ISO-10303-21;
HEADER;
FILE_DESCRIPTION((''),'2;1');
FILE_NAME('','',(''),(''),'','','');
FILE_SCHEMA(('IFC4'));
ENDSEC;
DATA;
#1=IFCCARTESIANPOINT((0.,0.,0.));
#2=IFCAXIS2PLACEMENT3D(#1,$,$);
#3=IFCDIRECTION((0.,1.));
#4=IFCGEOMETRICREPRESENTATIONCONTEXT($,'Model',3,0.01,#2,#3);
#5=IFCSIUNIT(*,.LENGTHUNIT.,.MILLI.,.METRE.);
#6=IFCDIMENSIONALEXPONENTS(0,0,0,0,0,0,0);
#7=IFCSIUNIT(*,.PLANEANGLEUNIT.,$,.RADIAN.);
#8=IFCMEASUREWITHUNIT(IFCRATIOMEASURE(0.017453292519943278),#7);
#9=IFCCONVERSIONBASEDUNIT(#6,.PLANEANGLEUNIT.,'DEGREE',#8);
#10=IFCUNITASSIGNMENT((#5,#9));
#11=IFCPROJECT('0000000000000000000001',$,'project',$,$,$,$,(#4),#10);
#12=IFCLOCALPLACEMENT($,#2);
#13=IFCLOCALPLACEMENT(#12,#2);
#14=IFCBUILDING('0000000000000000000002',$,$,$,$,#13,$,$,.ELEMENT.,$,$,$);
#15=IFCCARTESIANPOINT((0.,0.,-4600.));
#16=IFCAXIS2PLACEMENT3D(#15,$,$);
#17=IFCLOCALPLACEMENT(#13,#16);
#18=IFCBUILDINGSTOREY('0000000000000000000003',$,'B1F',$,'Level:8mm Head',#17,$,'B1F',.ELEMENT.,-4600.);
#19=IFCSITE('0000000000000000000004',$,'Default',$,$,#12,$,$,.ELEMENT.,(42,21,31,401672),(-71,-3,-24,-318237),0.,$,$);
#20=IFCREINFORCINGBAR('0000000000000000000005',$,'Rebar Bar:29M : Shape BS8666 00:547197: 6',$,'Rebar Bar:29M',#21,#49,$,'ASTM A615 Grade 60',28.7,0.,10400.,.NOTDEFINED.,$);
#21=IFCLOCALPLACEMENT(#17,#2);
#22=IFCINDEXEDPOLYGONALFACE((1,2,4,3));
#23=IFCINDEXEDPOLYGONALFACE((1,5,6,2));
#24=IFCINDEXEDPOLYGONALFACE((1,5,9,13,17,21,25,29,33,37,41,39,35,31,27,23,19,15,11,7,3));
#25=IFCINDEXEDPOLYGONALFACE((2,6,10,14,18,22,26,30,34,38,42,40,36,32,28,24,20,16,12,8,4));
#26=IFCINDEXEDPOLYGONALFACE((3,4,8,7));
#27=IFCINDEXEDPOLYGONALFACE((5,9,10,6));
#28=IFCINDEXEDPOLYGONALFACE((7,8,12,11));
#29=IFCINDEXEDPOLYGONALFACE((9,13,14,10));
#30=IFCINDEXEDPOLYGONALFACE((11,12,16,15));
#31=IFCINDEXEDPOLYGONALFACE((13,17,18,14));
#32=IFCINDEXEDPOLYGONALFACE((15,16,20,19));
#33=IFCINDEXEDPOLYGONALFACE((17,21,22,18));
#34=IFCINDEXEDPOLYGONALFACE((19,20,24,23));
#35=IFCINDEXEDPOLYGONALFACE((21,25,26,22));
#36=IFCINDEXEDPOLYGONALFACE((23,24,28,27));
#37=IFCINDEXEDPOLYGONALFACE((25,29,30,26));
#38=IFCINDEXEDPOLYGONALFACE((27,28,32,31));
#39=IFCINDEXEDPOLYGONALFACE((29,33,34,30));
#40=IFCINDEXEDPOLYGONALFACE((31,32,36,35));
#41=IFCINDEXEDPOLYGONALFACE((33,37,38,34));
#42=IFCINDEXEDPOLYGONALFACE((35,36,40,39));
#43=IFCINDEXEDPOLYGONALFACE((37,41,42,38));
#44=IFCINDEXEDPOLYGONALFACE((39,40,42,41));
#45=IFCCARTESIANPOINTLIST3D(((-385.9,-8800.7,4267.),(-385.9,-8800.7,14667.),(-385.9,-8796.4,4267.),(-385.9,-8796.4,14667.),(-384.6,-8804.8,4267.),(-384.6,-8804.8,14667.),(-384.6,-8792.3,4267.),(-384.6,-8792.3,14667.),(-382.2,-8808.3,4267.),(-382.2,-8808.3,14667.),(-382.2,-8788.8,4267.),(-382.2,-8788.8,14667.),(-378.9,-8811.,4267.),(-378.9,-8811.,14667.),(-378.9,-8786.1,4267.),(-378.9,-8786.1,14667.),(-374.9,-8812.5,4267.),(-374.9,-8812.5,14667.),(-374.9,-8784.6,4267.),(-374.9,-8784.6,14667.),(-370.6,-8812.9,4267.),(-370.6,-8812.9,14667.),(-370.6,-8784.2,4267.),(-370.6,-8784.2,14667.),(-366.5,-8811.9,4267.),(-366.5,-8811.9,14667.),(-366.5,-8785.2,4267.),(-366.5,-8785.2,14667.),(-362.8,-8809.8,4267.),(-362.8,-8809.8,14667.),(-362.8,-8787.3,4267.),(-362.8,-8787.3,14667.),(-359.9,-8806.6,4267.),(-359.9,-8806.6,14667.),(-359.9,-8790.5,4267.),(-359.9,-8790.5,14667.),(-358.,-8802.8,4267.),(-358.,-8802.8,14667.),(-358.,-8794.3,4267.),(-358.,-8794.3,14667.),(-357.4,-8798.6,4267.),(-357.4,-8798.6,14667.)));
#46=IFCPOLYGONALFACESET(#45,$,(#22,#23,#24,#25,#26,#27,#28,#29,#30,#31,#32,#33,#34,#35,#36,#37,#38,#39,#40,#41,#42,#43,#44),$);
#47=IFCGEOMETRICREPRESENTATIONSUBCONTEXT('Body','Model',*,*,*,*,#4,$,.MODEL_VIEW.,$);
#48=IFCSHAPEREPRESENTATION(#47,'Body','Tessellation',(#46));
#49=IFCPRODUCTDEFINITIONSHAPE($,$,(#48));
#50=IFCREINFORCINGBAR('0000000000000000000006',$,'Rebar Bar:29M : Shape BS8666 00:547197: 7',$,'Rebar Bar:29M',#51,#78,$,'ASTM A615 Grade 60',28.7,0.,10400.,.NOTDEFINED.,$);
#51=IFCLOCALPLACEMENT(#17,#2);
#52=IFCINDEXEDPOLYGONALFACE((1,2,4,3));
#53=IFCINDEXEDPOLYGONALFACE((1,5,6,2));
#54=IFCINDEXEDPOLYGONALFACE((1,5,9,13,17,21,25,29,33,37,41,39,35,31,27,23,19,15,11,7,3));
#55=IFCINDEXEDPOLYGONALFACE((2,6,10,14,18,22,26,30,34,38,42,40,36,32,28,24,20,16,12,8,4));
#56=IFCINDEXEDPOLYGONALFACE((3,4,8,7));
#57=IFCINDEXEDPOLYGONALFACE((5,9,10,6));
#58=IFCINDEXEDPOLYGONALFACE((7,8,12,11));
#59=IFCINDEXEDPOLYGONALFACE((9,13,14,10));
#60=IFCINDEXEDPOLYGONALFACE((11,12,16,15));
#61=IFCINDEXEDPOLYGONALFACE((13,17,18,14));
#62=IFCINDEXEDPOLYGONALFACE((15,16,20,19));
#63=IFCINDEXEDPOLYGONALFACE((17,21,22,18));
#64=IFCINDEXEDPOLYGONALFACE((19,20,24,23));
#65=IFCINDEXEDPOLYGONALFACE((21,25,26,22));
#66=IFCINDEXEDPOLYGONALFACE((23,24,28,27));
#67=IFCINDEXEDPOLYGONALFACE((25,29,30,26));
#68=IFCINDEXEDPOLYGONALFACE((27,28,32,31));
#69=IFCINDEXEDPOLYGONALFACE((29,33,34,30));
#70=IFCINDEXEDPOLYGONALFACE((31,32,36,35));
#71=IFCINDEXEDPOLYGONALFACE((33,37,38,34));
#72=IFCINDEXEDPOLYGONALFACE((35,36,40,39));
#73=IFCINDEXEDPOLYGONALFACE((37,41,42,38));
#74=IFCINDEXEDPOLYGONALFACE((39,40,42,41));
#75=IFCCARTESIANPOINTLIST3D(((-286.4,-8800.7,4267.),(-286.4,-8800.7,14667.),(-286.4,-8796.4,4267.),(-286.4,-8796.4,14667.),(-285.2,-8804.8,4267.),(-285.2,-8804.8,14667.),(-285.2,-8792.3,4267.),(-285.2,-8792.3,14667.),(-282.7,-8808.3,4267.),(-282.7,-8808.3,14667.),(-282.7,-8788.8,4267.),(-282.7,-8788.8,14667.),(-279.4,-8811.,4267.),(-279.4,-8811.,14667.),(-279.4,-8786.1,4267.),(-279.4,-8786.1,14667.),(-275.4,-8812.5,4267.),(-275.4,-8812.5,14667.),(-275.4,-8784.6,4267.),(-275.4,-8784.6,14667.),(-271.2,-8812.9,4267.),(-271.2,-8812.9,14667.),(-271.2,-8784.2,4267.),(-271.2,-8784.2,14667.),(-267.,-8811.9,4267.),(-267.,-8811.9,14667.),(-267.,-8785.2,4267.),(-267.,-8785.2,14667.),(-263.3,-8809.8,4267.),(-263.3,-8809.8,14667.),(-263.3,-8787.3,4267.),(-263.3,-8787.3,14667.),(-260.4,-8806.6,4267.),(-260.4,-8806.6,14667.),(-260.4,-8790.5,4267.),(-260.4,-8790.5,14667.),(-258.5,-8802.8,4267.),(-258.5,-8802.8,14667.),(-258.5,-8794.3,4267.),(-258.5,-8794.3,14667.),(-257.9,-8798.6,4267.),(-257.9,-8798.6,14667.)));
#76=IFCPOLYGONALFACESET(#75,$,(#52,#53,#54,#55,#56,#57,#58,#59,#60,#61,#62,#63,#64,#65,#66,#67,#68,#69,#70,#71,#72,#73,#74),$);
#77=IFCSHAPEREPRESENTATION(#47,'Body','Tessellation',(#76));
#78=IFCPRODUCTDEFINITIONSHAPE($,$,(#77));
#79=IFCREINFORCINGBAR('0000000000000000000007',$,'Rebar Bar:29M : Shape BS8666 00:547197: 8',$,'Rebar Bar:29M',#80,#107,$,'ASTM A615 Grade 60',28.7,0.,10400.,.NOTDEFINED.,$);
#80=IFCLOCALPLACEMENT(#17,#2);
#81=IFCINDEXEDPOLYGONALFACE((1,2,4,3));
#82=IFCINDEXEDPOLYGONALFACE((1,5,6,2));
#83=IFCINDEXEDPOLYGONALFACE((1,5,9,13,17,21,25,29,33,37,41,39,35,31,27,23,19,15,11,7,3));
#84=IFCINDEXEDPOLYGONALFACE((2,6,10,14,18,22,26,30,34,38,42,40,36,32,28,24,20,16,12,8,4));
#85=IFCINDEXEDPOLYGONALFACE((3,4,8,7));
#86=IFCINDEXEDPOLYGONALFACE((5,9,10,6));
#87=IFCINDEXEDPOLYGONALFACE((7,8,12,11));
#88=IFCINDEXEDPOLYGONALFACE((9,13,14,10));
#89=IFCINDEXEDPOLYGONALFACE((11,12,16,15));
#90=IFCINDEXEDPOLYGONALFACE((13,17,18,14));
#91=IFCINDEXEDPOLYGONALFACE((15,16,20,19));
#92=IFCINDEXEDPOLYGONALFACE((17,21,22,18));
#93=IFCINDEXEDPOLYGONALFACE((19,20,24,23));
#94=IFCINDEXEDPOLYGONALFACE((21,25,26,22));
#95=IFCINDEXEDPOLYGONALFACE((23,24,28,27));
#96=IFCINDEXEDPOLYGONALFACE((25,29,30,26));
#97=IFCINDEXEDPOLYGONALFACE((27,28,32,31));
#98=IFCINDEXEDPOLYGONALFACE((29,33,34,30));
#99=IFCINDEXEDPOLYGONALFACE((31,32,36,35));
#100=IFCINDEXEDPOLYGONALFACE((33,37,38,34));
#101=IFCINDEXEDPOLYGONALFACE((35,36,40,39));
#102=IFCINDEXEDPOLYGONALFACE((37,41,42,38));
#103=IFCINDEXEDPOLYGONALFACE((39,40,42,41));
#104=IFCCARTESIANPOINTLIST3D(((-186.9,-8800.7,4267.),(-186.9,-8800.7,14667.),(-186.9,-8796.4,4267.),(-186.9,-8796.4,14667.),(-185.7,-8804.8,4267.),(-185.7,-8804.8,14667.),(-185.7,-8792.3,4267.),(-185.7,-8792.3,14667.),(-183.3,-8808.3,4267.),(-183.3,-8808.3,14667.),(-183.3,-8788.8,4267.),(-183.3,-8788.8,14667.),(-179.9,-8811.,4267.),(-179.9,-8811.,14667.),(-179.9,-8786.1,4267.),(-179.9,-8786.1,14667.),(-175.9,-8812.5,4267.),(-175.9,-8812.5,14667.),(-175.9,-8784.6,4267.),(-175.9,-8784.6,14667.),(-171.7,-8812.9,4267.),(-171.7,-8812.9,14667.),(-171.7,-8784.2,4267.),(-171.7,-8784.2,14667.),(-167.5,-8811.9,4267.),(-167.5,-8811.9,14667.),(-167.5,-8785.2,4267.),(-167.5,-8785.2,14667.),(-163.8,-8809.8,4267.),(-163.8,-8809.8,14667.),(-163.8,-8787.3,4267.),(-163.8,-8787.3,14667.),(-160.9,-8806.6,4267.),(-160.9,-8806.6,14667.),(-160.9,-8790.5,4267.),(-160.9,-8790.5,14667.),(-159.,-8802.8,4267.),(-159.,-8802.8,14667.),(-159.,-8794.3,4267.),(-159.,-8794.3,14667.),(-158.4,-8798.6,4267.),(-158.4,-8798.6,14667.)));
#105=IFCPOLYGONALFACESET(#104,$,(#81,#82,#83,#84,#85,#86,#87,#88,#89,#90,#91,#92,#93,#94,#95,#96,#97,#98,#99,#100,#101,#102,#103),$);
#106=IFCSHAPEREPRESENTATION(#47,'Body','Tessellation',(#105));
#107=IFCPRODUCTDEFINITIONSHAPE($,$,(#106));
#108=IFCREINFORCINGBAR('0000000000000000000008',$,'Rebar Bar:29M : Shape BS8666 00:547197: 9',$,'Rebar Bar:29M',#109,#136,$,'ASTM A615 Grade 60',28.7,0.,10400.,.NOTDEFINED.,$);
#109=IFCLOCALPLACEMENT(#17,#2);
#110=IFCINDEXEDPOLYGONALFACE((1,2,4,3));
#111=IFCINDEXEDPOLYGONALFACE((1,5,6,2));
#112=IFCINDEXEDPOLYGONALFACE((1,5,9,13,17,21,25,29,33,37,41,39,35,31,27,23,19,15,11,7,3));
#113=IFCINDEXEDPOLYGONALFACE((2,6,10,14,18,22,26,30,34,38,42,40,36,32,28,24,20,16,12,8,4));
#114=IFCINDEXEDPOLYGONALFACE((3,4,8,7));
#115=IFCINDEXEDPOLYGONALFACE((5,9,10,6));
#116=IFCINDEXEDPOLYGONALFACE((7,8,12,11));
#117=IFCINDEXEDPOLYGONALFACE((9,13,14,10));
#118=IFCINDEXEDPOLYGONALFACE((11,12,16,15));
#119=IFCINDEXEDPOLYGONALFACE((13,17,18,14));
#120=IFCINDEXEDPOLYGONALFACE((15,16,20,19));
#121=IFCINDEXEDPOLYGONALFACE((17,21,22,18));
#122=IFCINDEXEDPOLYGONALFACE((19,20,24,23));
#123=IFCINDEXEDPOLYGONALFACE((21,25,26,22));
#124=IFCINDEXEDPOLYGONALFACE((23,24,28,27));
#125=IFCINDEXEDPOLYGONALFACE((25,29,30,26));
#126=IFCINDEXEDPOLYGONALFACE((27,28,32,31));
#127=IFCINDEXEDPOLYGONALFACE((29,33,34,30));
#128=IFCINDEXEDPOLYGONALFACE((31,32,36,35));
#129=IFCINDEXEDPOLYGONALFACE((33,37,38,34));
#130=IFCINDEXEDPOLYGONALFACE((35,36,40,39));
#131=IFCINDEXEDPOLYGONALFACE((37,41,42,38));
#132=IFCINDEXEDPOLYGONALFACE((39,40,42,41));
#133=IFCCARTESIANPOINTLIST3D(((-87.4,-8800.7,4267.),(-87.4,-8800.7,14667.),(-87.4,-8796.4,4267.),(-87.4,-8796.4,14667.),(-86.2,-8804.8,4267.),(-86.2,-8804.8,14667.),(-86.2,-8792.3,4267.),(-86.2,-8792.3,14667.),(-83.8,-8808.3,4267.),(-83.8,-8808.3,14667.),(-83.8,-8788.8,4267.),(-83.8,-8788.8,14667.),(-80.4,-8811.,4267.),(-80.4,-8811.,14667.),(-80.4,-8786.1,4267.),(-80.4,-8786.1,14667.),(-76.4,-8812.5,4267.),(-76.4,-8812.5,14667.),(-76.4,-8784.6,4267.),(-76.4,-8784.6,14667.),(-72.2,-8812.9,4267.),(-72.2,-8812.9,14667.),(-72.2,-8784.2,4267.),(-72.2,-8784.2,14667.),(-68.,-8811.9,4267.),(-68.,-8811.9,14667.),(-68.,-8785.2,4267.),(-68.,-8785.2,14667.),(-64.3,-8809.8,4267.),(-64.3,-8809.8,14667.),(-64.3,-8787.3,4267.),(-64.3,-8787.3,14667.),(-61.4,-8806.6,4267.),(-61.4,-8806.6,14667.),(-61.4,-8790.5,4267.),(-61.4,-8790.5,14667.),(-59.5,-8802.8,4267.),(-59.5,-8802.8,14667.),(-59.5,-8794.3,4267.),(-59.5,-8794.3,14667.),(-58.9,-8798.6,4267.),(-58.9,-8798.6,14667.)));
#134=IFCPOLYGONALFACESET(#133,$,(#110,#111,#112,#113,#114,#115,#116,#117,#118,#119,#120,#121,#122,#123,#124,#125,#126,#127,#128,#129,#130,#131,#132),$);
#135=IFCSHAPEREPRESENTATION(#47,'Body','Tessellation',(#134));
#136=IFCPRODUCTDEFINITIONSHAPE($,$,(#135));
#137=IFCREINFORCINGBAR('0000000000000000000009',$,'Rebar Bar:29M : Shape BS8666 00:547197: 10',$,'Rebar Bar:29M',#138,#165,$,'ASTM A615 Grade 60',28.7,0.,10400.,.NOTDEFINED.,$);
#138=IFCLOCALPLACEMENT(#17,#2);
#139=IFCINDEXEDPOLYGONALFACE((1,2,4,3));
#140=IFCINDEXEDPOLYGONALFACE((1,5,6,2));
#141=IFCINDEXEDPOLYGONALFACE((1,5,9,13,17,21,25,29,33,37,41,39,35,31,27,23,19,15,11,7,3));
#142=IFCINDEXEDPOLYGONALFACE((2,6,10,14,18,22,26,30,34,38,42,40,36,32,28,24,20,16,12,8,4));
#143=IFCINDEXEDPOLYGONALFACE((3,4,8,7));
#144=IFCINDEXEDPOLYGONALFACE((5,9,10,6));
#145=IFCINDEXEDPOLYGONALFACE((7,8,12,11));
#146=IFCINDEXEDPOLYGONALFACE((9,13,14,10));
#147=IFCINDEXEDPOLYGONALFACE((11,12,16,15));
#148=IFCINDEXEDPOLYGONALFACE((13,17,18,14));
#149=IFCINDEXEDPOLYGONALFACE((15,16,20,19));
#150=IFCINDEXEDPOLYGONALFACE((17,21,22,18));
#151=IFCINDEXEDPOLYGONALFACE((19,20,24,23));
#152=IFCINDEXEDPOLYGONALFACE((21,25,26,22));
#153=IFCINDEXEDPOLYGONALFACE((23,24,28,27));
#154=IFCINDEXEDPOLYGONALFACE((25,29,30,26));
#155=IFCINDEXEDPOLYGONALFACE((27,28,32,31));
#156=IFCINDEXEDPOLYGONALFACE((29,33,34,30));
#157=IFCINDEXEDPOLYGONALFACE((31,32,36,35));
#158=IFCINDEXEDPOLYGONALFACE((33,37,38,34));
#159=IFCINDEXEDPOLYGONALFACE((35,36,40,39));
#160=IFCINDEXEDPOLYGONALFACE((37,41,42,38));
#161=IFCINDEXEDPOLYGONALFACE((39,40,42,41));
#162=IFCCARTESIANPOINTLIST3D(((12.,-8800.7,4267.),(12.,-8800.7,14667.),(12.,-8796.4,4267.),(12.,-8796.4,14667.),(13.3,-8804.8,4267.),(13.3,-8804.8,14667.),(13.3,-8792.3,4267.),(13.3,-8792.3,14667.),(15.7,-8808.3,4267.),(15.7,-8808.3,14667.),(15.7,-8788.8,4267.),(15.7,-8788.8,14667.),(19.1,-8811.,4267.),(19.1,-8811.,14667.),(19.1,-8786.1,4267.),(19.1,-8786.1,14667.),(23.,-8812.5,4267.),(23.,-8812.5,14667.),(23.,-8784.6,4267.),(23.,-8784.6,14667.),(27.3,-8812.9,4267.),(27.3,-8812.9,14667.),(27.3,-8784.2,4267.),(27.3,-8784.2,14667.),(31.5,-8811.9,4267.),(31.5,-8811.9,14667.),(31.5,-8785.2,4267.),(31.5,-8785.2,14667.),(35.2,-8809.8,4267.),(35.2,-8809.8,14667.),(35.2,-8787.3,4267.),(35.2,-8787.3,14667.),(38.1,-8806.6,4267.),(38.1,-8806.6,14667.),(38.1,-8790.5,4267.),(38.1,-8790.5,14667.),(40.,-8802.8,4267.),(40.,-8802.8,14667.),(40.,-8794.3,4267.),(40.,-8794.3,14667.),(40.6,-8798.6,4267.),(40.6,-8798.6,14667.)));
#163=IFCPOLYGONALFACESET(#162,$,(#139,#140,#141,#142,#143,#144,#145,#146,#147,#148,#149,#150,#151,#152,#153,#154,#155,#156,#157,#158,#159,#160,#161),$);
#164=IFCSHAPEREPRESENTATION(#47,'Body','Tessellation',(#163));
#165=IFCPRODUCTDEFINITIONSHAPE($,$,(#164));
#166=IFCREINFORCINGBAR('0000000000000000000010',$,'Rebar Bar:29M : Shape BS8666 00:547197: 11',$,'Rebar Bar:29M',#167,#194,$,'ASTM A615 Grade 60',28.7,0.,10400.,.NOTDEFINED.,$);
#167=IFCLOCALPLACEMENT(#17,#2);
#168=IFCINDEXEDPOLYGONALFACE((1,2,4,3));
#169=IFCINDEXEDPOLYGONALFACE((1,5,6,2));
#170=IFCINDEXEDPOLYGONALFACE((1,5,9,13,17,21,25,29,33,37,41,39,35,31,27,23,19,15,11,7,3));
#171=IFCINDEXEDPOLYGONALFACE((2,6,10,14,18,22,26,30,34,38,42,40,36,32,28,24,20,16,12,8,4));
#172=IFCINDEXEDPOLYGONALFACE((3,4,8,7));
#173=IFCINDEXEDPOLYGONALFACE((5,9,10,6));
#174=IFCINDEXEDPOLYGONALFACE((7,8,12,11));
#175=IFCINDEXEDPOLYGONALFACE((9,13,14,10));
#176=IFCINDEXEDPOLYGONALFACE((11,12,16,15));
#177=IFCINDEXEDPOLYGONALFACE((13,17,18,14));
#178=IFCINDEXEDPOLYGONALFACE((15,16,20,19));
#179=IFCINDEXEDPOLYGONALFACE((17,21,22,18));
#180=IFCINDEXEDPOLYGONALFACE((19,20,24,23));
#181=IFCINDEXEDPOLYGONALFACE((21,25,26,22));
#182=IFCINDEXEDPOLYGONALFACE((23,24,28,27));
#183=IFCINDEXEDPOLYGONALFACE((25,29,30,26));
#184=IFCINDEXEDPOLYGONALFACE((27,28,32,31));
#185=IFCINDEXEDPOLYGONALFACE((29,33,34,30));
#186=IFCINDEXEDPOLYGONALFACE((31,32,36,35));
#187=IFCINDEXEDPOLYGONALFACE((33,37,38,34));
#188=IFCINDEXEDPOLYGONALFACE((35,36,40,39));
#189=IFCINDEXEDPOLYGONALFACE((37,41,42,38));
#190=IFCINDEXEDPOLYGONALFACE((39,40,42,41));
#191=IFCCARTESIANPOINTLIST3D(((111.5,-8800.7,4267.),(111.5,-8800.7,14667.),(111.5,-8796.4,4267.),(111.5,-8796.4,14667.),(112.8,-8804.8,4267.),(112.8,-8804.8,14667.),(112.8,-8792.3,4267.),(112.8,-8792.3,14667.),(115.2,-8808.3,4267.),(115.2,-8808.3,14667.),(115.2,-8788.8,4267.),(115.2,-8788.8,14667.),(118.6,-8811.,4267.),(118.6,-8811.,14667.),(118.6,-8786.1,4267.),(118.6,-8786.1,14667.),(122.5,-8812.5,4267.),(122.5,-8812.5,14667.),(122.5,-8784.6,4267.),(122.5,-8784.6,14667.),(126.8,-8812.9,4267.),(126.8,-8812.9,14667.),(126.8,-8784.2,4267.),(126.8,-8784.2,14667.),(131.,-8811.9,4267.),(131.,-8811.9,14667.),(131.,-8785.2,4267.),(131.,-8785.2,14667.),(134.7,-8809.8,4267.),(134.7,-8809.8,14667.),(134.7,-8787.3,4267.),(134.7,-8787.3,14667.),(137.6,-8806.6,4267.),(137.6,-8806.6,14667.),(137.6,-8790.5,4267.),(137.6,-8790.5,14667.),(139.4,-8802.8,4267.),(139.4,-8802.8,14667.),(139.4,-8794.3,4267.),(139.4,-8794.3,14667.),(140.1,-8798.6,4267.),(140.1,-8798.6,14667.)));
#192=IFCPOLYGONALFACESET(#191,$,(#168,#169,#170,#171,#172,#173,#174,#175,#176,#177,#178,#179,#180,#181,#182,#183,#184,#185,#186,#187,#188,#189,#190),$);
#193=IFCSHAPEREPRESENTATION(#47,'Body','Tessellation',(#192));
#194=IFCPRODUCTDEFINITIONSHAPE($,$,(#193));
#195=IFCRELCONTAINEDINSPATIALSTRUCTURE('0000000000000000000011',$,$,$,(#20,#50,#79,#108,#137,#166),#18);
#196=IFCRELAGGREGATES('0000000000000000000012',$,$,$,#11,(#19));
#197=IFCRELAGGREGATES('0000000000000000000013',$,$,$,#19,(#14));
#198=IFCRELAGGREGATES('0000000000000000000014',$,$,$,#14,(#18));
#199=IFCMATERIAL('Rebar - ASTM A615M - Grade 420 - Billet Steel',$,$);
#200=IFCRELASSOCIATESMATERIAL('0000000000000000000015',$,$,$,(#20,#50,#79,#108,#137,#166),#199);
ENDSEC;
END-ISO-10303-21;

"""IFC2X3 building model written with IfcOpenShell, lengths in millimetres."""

from ifc_helpers import new_model, entity, si_unit, converted_unit, direction, frame, origin, place, context, subcontext, project, spatial, material, element, save


model = new_model("IFC2X3")

# Units and contexts
model_context = context("Model", 3, precision=0.01, world=origin(), true_north=direction((0.0, 1.0)))
body_context = subcontext(model_context, "Body", "Model", "MODEL_VIEW")
ifc_project = project(units=[si_unit("LENGTHUNIT", "METRE", prefix="MILLI"), converted_unit("PLANEANGLEUNIT", "DEGREE", entity("IfcRatioMeasure", 0.017453292519943278), si_unit("PLANEANGLEUNIT", "RADIAN"), dimensions=[0, 0, 0, 0, 0, 0, 0])], contexts=[model_context])

# Site, building, storey
site_placement = place(None, origin())
site = spatial("IfcSite", under=ifc_project, at=site_placement, Name="Default", CompositionType="ELEMENT", RefLatitude=(42, 21, 31, 401672), RefLongitude=(-71, -3, -24, -318237), RefElevation=0.0)
building_placement = place(site_placement, origin())
building = spatial("IfcBuilding", under=site, at=building_placement, CompositionType="ELEMENT")
storey_placement = place(building_placement, frame((0.0, 0.0, -4600.0)))
storey = spatial("IfcBuildingStorey", under=building, at=storey_placement, Name="B1F", ObjectType="Level:8mm Head", LongName="B1F", CompositionType="ELEMENT", Elevation=-4600.0)

# Reinforcing bars
ifc_material = material(Name="Rebar - ASTM A615M - Grade 420 - Billet Steel")
reinforcing_bar_1_placement = place(storey_placement, origin())
element("IfcReinforcingBar", 1, at=reinforcing_bar_1_placement, inside=storey, material=ifc_material, Name="Rebar Bar:29M : Shape BS8666 00:547197: 6", SteelGrade="ASTM A615 Grade 60", ObjectType="Rebar Bar:29M", BarLength=10400.0, BarRole="NOTDEFINED", CrossSectionArea=0.0, NominalDiameter=28.7, context=body_context, shape_type="AdvancedSweptSolid", body=[
    entity("IfcSweptDiskSolid", entity("IfcCompositeCurve", [entity("IfcCompositeCurveSegment", "CONTINUOUS", True, entity("IfcPolyline", [entity("IfcCartesianPoint", [-371.7, -8798.6, 4267.0]), entity("IfcCartesianPoint", [-371.7, -8798.6, 14667.0])]))], False), 14.3, None, 0.0, 1.0),
])
reinforcing_bar_2_placement = place(storey_placement, origin())
element("IfcReinforcingBar", 2, at=reinforcing_bar_2_placement, inside=storey, material=ifc_material, Name="Rebar Bar:29M : Shape BS8666 00:547197: 7", SteelGrade="ASTM A615 Grade 60", ObjectType="Rebar Bar:29M", BarLength=10400.0, BarRole="NOTDEFINED", CrossSectionArea=0.0, NominalDiameter=28.7, context=body_context, shape_type="AdvancedSweptSolid", body=[
    entity("IfcSweptDiskSolid", entity("IfcCompositeCurve", [entity("IfcCompositeCurveSegment", "CONTINUOUS", True, entity("IfcPolyline", [entity("IfcCartesianPoint", [-272.2, -8798.6, 4267.0]), entity("IfcCartesianPoint", [-272.2, -8798.6, 14667.0])]))], False), 14.3, None, 0.0, 1.0),
])
reinforcing_bar_3_placement = place(storey_placement, origin())
element("IfcReinforcingBar", 3, at=reinforcing_bar_3_placement, inside=storey, material=ifc_material, Name="Rebar Bar:29M : Shape BS8666 00:547197: 8", SteelGrade="ASTM A615 Grade 60", ObjectType="Rebar Bar:29M", BarLength=10400.0, BarRole="NOTDEFINED", CrossSectionArea=0.0, NominalDiameter=28.7, context=body_context, shape_type="AdvancedSweptSolid", body=[
    entity("IfcSweptDiskSolid", entity("IfcCompositeCurve", [entity("IfcCompositeCurveSegment", "CONTINUOUS", True, entity("IfcPolyline", [entity("IfcCartesianPoint", [-172.7, -8798.6, 4267.0]), entity("IfcCartesianPoint", [-172.7, -8798.6, 14667.0])]))], False), 14.3, None, 0.0, 1.0),
])
reinforcing_bar_4_placement = place(storey_placement, origin())
element("IfcReinforcingBar", 4, at=reinforcing_bar_4_placement, inside=storey, material=ifc_material, Name="Rebar Bar:29M : Shape BS8666 00:547197: 9", SteelGrade="ASTM A615 Grade 60", ObjectType="Rebar Bar:29M", BarLength=10400.0, BarRole="NOTDEFINED", CrossSectionArea=0.0, NominalDiameter=28.7, context=body_context, shape_type="AdvancedSweptSolid", body=[
    entity("IfcSweptDiskSolid", entity("IfcCompositeCurve", [entity("IfcCompositeCurveSegment", "CONTINUOUS", True, entity("IfcPolyline", [entity("IfcCartesianPoint", [-73.3, -8798.6, 4267.0]), entity("IfcCartesianPoint", [-73.3, -8798.6, 14667.0])]))], False), 14.3, None, 0.0, 1.0),
])
reinforcing_bar_5_placement = place(storey_placement, origin())
element("IfcReinforcingBar", 5, at=reinforcing_bar_5_placement, inside=storey, material=ifc_material, Name="Rebar Bar:29M : Shape BS8666 00:547197: 10", SteelGrade="ASTM A615 Grade 60", ObjectType="Rebar Bar:29M", BarLength=10400.0, BarRole="NOTDEFINED", CrossSectionArea=0.0, NominalDiameter=28.7, context=body_context, shape_type="AdvancedSweptSolid", body=[
    entity("IfcSweptDiskSolid", entity("IfcCompositeCurve", [entity("IfcCompositeCurveSegment", "CONTINUOUS", True, entity("IfcPolyline", [entity("IfcCartesianPoint", [26.2, -8798.6, 4267.0]), entity("IfcCartesianPoint", [26.2, -8798.6, 14667.0])]))], False), 14.3, None, 0.0, 1.0),
])
reinforcing_bar_6_placement = place(storey_placement, origin())
element("IfcReinforcingBar", 6, at=reinforcing_bar_6_placement, inside=storey, material=ifc_material, Name="Rebar Bar:29M : Shape BS8666 00:547197: 11", SteelGrade="ASTM A615 Grade 60", ObjectType="Rebar Bar:29M", BarLength=10400.0, BarRole="NOTDEFINED", CrossSectionArea=0.0, NominalDiameter=28.7, context=body_context, shape_type="AdvancedSweptSolid", body=[
    entity("IfcSweptDiskSolid", entity("IfcCompositeCurve", [entity("IfcCompositeCurveSegment", "CONTINUOUS", True, entity("IfcPolyline", [entity("IfcCartesianPoint", [125.7, -8798.6, 4267.0]), entity("IfcCartesianPoint", [125.7, -8798.6, 14667.0])]))], False), 14.3, None, 0.0, 1.0),
])

save(model, "model.ifc")
